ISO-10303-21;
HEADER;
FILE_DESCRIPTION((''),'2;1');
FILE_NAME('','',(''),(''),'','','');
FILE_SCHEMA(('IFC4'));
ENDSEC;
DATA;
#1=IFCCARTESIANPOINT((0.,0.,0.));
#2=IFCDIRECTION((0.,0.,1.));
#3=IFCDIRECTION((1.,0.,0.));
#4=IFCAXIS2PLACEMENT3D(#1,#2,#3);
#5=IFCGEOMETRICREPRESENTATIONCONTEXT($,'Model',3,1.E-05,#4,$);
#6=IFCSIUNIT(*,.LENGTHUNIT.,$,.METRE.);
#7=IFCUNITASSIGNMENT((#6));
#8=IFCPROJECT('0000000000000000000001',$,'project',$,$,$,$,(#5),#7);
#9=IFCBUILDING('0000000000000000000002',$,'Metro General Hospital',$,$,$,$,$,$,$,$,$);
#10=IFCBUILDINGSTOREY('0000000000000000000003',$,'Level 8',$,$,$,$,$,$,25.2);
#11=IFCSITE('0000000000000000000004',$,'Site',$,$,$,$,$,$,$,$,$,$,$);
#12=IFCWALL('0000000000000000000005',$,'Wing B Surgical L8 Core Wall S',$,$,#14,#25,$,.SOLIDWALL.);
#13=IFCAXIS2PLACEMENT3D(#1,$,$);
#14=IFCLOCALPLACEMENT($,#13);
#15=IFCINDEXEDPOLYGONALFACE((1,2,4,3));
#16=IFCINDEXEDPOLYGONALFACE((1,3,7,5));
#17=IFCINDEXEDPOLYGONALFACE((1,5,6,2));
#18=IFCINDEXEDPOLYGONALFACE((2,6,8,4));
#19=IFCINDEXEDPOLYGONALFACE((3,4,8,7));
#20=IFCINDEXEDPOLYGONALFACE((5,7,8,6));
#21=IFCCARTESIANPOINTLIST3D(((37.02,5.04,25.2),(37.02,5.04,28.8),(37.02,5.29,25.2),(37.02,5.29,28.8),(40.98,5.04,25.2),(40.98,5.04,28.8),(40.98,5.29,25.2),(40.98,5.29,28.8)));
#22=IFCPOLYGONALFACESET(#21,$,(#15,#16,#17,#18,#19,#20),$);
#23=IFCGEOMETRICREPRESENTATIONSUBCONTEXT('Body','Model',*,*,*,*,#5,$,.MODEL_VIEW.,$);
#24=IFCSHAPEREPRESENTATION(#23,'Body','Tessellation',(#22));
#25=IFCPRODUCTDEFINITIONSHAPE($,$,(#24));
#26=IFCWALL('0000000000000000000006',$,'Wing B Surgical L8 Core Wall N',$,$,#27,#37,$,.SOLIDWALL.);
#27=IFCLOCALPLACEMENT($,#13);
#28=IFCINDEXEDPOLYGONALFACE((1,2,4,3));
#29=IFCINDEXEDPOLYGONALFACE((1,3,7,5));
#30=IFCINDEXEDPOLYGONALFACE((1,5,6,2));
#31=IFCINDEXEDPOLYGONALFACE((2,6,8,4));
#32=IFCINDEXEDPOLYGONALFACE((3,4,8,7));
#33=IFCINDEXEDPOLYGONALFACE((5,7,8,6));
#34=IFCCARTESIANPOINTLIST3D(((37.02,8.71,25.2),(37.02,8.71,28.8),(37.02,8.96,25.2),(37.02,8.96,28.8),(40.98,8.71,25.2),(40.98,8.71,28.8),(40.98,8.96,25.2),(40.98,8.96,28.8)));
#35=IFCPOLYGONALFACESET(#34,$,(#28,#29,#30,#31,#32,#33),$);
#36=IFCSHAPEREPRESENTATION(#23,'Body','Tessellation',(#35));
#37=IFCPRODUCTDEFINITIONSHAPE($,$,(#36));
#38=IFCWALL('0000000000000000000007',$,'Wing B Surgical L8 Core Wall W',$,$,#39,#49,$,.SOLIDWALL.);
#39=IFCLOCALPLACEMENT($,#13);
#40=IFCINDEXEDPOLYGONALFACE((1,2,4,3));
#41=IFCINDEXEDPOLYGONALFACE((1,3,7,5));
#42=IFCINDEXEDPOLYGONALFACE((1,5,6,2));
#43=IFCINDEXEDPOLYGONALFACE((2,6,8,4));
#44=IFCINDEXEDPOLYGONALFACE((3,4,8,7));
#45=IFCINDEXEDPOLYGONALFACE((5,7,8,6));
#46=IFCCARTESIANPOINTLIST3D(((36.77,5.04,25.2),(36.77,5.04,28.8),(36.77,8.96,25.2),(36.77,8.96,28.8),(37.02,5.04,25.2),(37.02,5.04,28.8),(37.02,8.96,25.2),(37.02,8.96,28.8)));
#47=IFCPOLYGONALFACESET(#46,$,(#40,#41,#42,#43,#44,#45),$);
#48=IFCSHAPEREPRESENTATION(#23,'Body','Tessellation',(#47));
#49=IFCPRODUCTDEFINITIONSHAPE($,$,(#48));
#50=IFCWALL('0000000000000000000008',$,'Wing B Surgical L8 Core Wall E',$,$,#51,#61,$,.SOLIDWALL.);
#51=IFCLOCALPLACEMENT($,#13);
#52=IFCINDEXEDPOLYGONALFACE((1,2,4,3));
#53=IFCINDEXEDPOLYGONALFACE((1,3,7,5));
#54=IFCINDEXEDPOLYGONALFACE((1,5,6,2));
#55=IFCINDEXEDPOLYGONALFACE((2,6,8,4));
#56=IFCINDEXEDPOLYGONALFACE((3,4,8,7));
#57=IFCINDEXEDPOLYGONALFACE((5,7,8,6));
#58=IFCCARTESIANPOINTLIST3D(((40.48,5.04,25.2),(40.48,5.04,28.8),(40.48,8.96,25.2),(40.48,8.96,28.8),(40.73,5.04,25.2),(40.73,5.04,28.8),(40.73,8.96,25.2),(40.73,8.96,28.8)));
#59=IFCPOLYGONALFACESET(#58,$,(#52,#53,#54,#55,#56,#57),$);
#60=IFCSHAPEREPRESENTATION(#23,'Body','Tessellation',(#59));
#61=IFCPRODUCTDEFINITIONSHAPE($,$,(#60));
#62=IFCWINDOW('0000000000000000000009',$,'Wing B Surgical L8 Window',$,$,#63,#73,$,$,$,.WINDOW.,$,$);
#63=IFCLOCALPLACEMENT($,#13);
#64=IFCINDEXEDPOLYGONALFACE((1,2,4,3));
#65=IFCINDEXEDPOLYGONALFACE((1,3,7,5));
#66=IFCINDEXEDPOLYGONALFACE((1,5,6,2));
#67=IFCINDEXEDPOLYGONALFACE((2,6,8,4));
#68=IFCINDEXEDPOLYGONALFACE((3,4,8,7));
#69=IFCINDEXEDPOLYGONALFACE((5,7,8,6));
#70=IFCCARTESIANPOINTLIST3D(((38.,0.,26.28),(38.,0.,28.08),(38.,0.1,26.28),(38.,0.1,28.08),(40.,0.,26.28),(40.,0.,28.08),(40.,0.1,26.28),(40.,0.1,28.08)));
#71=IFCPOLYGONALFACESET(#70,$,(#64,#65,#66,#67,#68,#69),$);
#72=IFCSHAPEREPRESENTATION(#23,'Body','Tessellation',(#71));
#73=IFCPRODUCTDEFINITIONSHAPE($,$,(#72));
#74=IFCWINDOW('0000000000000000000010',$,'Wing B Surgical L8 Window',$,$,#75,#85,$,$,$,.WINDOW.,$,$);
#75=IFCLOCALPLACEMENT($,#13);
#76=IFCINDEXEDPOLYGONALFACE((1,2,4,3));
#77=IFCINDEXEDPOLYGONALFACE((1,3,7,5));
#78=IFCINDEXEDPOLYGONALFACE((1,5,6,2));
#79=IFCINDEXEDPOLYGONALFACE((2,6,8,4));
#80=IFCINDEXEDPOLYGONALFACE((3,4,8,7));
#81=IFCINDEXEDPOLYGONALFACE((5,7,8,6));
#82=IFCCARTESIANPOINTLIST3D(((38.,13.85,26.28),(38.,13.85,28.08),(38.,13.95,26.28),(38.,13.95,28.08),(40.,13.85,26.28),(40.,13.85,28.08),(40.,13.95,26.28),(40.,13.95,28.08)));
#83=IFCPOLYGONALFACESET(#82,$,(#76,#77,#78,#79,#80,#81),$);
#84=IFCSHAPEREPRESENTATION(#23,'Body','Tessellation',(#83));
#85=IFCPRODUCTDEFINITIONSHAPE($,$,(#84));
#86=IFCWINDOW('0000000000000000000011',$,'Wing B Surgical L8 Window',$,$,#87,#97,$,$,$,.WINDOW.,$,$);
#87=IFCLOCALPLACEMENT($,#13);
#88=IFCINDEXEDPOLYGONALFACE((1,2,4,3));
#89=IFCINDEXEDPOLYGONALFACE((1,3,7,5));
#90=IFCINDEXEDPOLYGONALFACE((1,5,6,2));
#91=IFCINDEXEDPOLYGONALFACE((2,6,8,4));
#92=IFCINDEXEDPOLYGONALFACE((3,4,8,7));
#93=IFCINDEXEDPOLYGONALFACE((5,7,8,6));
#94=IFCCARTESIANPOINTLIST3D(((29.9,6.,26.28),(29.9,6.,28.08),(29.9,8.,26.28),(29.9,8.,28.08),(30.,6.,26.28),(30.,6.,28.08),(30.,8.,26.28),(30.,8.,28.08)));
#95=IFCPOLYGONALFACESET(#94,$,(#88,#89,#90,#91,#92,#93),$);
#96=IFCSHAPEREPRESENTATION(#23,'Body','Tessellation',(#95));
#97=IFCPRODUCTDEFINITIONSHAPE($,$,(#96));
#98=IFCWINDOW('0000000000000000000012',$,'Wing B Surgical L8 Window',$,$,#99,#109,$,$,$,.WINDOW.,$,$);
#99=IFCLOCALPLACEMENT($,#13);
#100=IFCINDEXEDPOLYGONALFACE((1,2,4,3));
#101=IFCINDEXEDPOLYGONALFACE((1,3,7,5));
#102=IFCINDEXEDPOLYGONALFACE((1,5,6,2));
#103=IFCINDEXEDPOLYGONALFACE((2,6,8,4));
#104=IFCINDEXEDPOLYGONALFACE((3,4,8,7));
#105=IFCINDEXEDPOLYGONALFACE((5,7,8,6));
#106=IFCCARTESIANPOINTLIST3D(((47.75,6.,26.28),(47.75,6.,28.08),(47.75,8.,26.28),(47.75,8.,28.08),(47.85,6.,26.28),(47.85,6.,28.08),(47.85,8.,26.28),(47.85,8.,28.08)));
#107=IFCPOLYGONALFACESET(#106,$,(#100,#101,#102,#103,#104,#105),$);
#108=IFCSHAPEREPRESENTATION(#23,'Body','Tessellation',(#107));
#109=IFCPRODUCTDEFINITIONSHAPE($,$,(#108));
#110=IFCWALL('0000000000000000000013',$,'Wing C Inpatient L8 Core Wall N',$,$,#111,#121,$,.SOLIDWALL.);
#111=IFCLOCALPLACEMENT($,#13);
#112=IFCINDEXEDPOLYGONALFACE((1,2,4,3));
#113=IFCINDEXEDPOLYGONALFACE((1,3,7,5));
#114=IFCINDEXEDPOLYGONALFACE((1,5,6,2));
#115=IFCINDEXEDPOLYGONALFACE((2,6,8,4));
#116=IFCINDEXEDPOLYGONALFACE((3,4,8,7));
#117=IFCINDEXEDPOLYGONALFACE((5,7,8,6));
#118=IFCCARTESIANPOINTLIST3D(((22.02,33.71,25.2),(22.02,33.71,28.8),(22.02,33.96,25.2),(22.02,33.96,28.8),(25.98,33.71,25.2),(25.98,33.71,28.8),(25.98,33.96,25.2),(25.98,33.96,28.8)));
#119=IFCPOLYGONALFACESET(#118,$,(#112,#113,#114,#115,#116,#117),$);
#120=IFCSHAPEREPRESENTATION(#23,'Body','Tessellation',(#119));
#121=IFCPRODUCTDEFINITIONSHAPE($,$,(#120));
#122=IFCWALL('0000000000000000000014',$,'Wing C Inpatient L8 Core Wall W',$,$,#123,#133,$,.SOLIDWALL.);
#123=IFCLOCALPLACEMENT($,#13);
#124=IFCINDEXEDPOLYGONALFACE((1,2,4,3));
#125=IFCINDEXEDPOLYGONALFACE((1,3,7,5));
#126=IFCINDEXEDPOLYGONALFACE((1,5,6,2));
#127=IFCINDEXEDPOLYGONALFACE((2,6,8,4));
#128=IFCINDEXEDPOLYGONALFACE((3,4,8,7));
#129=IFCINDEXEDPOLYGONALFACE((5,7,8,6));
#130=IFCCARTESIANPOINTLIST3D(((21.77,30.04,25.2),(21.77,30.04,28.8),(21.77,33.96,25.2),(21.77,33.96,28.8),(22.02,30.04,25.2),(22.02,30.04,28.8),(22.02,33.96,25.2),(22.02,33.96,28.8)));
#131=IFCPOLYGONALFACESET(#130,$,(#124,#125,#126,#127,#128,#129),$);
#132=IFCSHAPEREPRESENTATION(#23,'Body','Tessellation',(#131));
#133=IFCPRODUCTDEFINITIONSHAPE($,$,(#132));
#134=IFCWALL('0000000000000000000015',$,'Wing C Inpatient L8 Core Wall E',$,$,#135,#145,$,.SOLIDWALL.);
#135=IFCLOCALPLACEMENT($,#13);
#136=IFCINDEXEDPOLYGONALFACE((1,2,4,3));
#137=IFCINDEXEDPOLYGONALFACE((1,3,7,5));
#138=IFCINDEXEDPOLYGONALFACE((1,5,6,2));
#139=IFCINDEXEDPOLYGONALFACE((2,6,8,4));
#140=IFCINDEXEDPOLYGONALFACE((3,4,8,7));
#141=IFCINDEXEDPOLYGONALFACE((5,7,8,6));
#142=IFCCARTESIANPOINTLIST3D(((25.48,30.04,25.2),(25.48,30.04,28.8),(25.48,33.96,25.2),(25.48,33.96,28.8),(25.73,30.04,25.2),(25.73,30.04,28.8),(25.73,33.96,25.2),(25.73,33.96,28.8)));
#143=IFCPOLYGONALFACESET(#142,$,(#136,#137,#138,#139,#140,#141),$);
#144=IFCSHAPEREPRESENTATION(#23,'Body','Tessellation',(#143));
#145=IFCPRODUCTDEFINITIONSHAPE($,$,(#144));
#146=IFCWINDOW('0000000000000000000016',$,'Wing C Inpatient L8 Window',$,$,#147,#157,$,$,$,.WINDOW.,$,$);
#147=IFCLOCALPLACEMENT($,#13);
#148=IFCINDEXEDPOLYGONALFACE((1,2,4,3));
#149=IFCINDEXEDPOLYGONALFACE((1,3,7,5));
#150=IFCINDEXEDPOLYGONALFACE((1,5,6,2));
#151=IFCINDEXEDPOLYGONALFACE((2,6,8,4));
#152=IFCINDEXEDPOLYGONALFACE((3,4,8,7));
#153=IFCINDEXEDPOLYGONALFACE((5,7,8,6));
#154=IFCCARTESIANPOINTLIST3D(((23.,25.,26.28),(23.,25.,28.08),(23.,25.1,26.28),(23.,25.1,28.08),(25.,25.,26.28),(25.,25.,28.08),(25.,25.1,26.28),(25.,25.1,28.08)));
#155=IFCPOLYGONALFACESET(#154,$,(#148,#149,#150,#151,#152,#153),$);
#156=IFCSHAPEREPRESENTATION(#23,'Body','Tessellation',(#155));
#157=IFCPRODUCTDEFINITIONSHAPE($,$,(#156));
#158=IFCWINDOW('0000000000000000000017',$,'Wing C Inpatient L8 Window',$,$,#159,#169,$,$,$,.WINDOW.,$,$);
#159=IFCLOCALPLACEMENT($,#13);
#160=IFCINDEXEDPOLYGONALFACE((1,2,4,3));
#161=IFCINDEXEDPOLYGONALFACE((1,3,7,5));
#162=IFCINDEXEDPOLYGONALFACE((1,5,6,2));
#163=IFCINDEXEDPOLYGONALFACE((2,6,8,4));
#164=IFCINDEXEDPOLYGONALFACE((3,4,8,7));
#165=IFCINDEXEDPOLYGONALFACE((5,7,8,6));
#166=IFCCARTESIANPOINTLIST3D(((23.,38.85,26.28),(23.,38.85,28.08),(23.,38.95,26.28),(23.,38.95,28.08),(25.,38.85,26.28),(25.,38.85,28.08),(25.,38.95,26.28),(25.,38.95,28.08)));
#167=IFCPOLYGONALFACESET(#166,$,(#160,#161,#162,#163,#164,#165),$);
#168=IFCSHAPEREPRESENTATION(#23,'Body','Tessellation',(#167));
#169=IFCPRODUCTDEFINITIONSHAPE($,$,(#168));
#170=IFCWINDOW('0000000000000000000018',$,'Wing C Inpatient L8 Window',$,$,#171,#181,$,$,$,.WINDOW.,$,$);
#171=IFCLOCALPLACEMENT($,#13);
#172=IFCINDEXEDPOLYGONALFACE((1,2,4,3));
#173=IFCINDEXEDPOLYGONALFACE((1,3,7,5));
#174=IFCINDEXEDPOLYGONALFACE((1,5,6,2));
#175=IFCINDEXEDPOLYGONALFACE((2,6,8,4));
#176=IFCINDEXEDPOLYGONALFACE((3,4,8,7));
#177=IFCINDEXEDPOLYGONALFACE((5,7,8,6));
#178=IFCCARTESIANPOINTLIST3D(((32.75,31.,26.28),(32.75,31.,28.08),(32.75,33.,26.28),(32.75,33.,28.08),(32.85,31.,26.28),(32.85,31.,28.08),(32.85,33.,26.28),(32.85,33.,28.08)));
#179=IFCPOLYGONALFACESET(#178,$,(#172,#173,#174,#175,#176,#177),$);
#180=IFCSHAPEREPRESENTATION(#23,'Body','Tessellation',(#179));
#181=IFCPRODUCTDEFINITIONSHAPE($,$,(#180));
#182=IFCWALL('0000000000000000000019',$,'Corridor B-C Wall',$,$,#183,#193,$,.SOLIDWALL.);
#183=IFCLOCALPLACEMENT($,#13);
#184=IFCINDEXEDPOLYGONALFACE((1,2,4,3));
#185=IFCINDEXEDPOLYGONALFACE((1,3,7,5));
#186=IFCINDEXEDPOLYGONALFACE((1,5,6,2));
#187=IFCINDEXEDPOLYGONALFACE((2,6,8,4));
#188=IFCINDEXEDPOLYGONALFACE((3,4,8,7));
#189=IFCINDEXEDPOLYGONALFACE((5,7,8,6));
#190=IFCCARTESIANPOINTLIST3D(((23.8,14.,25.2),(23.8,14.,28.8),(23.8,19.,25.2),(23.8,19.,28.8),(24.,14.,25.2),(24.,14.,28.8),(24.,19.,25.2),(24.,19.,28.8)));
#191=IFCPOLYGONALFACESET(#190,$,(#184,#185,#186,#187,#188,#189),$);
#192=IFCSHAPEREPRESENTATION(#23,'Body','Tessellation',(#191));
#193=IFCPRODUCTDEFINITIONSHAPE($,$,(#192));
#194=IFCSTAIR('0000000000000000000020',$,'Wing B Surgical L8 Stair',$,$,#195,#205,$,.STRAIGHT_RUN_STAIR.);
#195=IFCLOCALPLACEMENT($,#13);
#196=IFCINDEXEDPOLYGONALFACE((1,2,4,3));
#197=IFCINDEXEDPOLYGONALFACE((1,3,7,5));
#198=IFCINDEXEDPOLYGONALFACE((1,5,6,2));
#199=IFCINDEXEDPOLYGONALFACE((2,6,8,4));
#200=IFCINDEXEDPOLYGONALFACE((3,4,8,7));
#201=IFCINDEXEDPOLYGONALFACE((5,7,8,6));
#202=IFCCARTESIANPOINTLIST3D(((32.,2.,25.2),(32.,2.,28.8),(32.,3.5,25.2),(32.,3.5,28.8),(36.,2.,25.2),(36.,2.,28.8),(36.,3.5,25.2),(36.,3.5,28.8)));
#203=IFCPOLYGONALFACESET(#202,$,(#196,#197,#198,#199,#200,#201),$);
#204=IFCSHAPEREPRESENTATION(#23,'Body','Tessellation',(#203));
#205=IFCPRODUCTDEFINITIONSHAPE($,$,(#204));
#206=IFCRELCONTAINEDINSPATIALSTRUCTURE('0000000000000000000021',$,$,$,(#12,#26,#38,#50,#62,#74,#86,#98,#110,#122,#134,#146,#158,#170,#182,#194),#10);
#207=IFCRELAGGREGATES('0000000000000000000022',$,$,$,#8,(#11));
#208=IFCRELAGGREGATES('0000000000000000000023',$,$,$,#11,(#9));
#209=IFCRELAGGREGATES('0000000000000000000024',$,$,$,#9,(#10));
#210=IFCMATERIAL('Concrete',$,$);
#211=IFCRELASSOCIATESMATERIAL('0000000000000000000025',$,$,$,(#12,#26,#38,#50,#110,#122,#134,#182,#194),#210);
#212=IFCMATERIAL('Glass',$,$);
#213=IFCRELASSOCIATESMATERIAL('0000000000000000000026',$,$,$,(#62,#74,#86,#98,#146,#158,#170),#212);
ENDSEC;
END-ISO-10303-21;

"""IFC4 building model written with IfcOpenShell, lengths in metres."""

from ifc_helpers import new_model, si_unit, frame, origin_with_axes, place, context, subcontext, project, spatial, line, indexed_curve, outline, extrude, material, element, save


model = new_model("IFC4")

# Units and contexts
model_context = context("Model", 3, precision=1e-05, world=origin_with_axes())
body_context = subcontext(model_context, "Body", "Model", "MODEL_VIEW")
ifc_project = project(units=[si_unit("LENGTHUNIT", "METRE")], contexts=[model_context])

# Site, building, storey
site = spatial("IfcSite", under=ifc_project, Name="Site")
building = spatial("IfcBuilding", under=site, Name="Metro General Hospital")
storey = spatial("IfcBuildingStorey", under=building, Name="Level 8", Elevation=25.2)

# Shared definitions
ifc_material_1 = material(Name="Concrete")

# Walls
for number, where, z_axis, x_axis, name in (
    (1, (37.02, 5.04, 25.2), (0.0, 0.0, 1.0), (1.0, 0.0, 0.0), "Wing B Surgical L8 Core Wall S"),
    (2, (37.02, 8.71, 25.2), (0.0, 0.0, 1.0), (1.0, 0.0, 0.0), "Wing B Surgical L8 Core Wall N"),
):
    element("IfcWall", number, at=place(None, frame(where, z_axis=z_axis, x_axis=x_axis)), inside=storey, material=ifc_material_1, Name=name, PredefinedType="SOLIDWALL", context=body_context, shape_type="SweptSolid", body=[
        extrude(outline(indexed_curve([(0.0, 0.0), (3.96, 0.0), (3.96, 0.25), (0.0, 0.25)], segments=[line(1, 2, 3, 4, 1)])), origin_with_axes(), (0.0, 0.0, 1.0), 3.6),
    ])
for number, where, z_axis, x_axis, name in (
    (3, (37.02, 5.04, 25.2), (0.0, 0.0, 1.0), (0.0, 1.0, 0.0), "Wing B Surgical L8 Core Wall W"),
    (4, (40.73, 5.04, 25.2), (0.0, 0.0, 1.0), (0.0, 1.0, 0.0), "Wing B Surgical L8 Core Wall E"),
):
    element("IfcWall", number, at=place(None, frame(where, z_axis=z_axis, x_axis=x_axis)), inside=storey, material=ifc_material_1, Name=name, PredefinedType="SOLIDWALL", context=body_context, shape_type="SweptSolid", body=[
        extrude(outline(indexed_curve([(0.0, 0.0), (3.92, 0.0), (3.92, 0.25), (0.0, 0.25)], segments=[line(1, 2, 3, 4, 1)])), origin_with_axes(), (0.0, 0.0, 1.0), 3.6),
    ])

# Windows
ifc_material_2 = material(Name="Glass")
for number, where, z_axis, x_axis, name in (
    (5, (38.0, 0.0, 26.28), (0.0, 0.0, 1.0), (1.0, 0.0, 0.0), "Wing B Surgical L8 Window"),
    (6, (38.0, 13.85, 26.28), (0.0, 0.0, 1.0), (1.0, 0.0, 0.0), "Wing B Surgical L8 Window"),
    (7, (30.0, 6.0, 26.28), (0.0, 0.0, 1.0), (0.0, 1.0, 0.0), "Wing B Surgical L8 Window"),
    (8, (47.85, 6.0, 26.28), (0.0, 0.0, 1.0), (0.0, 1.0, 0.0), "Wing B Surgical L8 Window"),
):
    element("IfcWindow", number, at=place(None, frame(where, z_axis=z_axis, x_axis=x_axis)), inside=storey, material=ifc_material_2, Name=name, PredefinedType="WINDOW", context=body_context, shape_type="SweptSolid", body=[
        extrude(outline(indexed_curve([(0.0, 0.0), (2.0, 0.0), (2.0, 0.1), (0.0, 0.1)], segments=[line(1, 2, 3, 4, 1)])), origin_with_axes(), (0.0, 0.0, 1.0), 1.8),
    ])

# Walls
wall_1_placement = place(None, frame((22.02, 33.71, 25.2), z_axis=(0.0, 0.0, 1.0), x_axis=(1.0, 0.0, 0.0)))
element("IfcWall", 9, at=wall_1_placement, inside=storey, material=ifc_material_1, Name="Wing C Inpatient L8 Core Wall N", PredefinedType="SOLIDWALL", context=body_context, shape_type="SweptSolid", body=[
    extrude(outline(indexed_curve([(0.0, 0.0), (3.96, 0.0), (3.96, 0.25), (0.0, 0.25)], segments=[line(1, 2, 3, 4, 1)])), origin_with_axes(), (0.0, 0.0, 1.0), 3.6),
])
for number, where, z_axis, x_axis, name in (
    (10, (22.02, 30.04, 25.2), (0.0, 0.0, 1.0), (0.0, 1.0, 0.0), "Wing C Inpatient L8 Core Wall W"),
    (11, (25.73, 30.04, 25.2), (0.0, 0.0, 1.0), (0.0, 1.0, 0.0), "Wing C Inpatient L8 Core Wall E"),
):
    element("IfcWall", number, at=place(None, frame(where, z_axis=z_axis, x_axis=x_axis)), inside=storey, material=ifc_material_1, Name=name, PredefinedType="SOLIDWALL", context=body_context, shape_type="SweptSolid", body=[
        extrude(outline(indexed_curve([(0.0, 0.0), (3.92, 0.0), (3.92, 0.25), (0.0, 0.25)], segments=[line(1, 2, 3, 4, 1)])), origin_with_axes(), (0.0, 0.0, 1.0), 3.6),
    ])

# Windows
for number, where, z_axis, x_axis, name in (
    (12, (23.0, 25.0, 26.28), (0.0, 0.0, 1.0), (1.0, 0.0, 0.0), "Wing C Inpatient L8 Window"),
    (13, (23.0, 38.85, 26.28), (0.0, 0.0, 1.0), (1.0, 0.0, 0.0), "Wing C Inpatient L8 Window"),
    (14, (32.85, 31.0, 26.28), (0.0, 0.0, 1.0), (0.0, 1.0, 0.0), "Wing C Inpatient L8 Window"),
):
    element("IfcWindow", number, at=place(None, frame(where, z_axis=z_axis, x_axis=x_axis)), inside=storey, material=ifc_material_2, Name=name, PredefinedType="WINDOW", context=body_context, shape_type="SweptSolid", body=[
        extrude(outline(indexed_curve([(0.0, 0.0), (2.0, 0.0), (2.0, 0.1), (0.0, 0.1)], segments=[line(1, 2, 3, 4, 1)])), origin_with_axes(), (0.0, 0.0, 1.0), 1.8),
    ])

# Wall
wall_2_placement = place(None, frame((24.0, 14.0, 25.2), z_axis=(0.0, 0.0, 1.0), x_axis=(0.0, 1.0, 0.0)))
element("IfcWall", 15, at=wall_2_placement, inside=storey, material=ifc_material_1, Name="Corridor B-C Wall", PredefinedType="SOLIDWALL", context=body_context, shape_type="SweptSolid", body=[
    extrude(outline(indexed_curve([(0.0, 0.0), (5.0, 0.0), (5.0, 0.2), (0.0, 0.2)], segments=[line(1, 2, 3, 4, 1)])), origin_with_axes(), (0.0, 0.0, 1.0), 3.6),
])

# Stair
stair_placement = place(None, frame((32.0, 2.0, 25.2), z_axis=(0.0, 0.0, 1.0), x_axis=(1.0, 0.0, 0.0)))
element("IfcStair", 16, at=stair_placement, inside=storey, material=ifc_material_1, Name="Wing B Surgical L8 Stair", PredefinedType="STRAIGHT_RUN_STAIR", context=body_context, shape_type="SweptSolid", body=[
    extrude(outline(indexed_curve([(0.0, 0.0), (4.0, 0.0), (4.0, 1.5), (0.0, 1.5)], segments=[line(1, 2, 3, 4, 1)])), origin_with_axes(), (0.0, 0.0, 1.0), 3.6),
])

save(model, "model.ifc")
